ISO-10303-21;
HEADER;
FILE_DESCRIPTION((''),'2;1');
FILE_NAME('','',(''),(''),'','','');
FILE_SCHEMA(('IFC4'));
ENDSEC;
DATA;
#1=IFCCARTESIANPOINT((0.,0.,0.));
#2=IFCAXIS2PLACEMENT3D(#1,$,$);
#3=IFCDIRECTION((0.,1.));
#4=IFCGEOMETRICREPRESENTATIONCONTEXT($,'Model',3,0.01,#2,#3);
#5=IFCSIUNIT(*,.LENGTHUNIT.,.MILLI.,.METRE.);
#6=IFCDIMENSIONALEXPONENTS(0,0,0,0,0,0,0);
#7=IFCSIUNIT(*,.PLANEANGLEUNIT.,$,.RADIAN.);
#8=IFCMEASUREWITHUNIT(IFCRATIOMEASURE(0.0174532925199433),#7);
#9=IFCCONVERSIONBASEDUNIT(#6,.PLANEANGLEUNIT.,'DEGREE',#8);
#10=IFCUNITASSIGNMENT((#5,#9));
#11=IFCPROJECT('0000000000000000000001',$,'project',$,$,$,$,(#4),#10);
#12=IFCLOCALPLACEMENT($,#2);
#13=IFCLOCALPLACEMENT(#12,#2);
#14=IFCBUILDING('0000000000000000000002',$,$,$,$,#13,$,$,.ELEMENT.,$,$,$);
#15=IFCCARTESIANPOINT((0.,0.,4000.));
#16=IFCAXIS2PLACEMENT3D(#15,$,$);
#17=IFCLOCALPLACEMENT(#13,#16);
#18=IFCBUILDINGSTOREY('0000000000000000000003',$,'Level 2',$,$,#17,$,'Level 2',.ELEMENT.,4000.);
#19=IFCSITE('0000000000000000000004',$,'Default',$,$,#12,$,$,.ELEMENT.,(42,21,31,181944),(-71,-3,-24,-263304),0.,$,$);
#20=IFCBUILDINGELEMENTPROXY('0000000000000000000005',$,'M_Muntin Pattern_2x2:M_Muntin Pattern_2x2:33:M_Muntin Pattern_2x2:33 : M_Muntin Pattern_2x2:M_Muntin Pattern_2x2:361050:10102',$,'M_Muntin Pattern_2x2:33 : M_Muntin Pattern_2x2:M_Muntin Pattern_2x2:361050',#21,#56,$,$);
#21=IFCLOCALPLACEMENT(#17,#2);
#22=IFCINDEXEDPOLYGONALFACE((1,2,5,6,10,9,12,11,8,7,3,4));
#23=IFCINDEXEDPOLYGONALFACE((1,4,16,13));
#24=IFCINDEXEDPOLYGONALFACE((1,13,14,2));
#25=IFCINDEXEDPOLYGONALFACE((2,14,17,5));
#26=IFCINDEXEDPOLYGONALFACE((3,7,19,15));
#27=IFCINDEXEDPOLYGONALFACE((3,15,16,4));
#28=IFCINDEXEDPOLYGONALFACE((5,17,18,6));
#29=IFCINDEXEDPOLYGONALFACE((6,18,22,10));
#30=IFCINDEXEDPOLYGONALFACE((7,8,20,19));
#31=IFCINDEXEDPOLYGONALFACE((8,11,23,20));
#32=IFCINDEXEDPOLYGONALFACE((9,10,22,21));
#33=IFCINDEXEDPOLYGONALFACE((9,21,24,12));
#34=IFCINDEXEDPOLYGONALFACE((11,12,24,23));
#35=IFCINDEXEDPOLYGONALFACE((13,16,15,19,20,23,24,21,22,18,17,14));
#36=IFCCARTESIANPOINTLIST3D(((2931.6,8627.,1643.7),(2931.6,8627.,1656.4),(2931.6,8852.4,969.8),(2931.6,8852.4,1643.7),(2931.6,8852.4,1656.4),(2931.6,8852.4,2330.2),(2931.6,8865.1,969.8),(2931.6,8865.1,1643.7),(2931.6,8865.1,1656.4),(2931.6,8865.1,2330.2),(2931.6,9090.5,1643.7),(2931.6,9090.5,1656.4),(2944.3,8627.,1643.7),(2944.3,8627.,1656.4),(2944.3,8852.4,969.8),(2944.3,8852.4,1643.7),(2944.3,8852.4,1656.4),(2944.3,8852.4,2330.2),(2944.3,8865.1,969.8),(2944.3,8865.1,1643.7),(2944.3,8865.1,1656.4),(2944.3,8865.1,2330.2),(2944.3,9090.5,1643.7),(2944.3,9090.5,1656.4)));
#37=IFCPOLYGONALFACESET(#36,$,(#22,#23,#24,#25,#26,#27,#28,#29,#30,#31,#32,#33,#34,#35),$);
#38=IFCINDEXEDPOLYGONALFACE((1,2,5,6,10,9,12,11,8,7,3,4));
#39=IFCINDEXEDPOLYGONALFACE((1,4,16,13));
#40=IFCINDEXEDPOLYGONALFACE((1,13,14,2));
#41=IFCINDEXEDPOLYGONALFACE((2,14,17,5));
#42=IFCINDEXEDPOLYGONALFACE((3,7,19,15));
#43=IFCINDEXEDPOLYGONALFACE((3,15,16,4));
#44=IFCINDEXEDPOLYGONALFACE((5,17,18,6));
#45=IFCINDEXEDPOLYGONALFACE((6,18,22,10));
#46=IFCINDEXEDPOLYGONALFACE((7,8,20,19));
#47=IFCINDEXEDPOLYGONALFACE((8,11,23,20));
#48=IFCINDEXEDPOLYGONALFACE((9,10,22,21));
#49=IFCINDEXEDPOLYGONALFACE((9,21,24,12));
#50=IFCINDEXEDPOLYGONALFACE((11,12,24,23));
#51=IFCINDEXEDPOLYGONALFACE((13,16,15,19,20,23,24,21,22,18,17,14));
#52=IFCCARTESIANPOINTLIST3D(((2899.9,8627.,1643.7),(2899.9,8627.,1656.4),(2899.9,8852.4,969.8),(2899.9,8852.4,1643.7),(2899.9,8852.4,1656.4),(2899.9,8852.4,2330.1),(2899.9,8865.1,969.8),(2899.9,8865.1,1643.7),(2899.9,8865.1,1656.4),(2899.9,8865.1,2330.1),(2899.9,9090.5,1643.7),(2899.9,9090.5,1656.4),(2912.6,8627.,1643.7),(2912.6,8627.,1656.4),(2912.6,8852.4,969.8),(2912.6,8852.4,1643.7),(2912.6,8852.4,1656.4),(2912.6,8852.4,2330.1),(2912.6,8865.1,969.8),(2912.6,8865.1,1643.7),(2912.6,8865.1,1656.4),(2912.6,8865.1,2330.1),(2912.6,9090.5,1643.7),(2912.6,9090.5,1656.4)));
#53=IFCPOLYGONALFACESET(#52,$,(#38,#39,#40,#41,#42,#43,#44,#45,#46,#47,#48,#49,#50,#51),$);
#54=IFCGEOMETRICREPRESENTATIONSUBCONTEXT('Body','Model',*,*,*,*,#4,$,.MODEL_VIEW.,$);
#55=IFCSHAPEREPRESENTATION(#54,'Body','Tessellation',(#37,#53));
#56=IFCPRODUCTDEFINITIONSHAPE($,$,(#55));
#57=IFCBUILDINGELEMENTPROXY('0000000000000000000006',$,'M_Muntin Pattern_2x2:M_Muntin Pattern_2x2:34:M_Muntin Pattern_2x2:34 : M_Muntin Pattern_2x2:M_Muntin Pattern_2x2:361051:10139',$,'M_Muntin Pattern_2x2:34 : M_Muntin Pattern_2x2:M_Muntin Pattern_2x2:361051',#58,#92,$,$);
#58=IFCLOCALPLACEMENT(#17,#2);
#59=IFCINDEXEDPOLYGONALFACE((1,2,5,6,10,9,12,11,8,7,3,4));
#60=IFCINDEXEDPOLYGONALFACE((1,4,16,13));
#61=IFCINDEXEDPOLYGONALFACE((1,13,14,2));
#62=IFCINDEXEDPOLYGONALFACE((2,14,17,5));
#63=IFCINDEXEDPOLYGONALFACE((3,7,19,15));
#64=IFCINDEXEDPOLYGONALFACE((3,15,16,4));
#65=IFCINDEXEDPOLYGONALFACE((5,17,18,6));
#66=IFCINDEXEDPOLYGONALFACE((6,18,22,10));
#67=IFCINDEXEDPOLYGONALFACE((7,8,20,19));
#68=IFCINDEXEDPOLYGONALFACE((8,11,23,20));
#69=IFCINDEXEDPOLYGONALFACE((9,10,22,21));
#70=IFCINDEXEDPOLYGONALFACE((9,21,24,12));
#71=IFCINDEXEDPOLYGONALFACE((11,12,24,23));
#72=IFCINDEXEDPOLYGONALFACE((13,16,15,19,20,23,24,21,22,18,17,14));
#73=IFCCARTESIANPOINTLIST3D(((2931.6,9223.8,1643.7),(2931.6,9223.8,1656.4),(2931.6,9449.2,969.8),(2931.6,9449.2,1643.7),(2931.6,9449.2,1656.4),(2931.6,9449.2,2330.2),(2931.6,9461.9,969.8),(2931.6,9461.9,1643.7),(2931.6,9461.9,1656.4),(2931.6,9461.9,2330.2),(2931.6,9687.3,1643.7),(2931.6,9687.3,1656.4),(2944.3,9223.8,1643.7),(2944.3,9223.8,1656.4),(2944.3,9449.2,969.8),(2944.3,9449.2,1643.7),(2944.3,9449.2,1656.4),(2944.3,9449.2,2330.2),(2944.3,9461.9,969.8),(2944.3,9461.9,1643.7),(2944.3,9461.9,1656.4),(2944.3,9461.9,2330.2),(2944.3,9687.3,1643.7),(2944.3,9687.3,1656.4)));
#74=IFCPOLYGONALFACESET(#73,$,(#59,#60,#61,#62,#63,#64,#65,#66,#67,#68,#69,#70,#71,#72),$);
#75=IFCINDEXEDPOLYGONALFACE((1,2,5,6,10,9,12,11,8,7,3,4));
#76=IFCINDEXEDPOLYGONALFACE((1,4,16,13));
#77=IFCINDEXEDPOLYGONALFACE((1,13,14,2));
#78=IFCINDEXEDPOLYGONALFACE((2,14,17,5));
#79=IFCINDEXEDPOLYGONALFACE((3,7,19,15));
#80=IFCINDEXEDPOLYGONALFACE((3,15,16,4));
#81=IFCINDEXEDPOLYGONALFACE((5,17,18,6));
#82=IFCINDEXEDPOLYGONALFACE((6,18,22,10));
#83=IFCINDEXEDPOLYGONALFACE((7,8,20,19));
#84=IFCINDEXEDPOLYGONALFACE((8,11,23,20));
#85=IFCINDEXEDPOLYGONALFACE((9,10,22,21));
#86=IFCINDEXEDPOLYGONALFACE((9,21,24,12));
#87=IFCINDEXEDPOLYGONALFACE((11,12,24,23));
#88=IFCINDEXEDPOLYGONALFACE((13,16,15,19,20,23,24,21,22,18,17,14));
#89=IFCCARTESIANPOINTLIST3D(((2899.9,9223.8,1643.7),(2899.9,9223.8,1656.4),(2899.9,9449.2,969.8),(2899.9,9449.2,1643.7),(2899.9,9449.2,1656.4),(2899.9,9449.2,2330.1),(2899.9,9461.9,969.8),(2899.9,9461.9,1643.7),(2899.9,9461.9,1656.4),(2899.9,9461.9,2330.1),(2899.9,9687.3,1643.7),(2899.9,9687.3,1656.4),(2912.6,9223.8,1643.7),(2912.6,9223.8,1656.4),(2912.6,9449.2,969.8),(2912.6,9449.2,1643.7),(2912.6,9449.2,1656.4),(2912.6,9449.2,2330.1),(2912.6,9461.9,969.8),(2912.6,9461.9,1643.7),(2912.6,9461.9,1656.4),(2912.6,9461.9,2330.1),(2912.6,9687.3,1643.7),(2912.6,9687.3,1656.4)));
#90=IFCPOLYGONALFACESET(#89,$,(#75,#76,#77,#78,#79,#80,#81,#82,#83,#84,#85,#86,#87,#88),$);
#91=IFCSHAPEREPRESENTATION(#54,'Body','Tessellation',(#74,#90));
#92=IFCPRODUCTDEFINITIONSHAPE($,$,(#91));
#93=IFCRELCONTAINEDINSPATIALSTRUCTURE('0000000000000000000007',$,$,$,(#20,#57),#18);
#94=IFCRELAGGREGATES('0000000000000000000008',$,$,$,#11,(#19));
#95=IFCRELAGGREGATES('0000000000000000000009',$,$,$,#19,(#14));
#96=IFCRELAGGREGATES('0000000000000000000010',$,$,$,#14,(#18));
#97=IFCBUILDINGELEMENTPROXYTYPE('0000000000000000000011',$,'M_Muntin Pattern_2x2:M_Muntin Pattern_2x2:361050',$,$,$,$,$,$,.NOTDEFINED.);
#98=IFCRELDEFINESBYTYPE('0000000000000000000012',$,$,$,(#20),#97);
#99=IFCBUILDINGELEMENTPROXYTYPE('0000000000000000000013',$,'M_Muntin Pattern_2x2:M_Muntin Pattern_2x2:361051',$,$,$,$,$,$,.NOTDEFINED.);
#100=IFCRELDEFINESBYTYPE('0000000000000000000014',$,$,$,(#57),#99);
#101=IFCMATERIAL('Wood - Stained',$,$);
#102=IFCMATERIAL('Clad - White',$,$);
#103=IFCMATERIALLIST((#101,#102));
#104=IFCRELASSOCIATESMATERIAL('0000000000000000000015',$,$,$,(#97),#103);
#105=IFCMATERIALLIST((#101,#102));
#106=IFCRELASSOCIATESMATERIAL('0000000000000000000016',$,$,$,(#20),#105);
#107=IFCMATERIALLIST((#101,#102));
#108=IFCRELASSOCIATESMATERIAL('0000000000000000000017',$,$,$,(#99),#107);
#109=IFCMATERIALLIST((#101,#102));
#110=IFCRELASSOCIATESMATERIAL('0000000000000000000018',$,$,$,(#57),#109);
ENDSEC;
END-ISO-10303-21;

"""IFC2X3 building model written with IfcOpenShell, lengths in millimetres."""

from ifc_helpers import new_model, entity, si_unit, converted_unit, direction, frame, origin, place, context, subcontext, project, spatial, polyline, outline, extrude, source, transform, mapped, material, material_list, type_object, type_shapes, element, save


model = new_model("IFC2X3")

# Units and contexts
model_context = context("Model", 3, precision=0.01, world=origin(), true_north=direction((0.0, 1.0)))
body_context = subcontext(model_context, "Body", "Model", "MODEL_VIEW")
ifc_project = project(units=[si_unit("LENGTHUNIT", "METRE", prefix="MILLI"), converted_unit("PLANEANGLEUNIT", "DEGREE", entity("IfcRatioMeasure", 0.0174532925199433), si_unit("PLANEANGLEUNIT", "RADIAN"), dimensions=[0, 0, 0, 0, 0, 0, 0])], contexts=[model_context])

# Site, building, storey
site_placement = place(None, origin())
site = spatial("IfcSite", under=ifc_project, at=site_placement, Name="Default", CompositionType="ELEMENT", RefLatitude=(42, 21, 31, 181944), RefLongitude=(-71, -3, -24, -263304), RefElevation=0.0)
building_placement = place(site_placement, origin())
building = spatial("IfcBuilding", under=site, at=building_placement, CompositionType="ELEMENT")
storey_placement = place(building_placement, frame((0.0, 0.0, 4000.0)))
storey = spatial("IfcBuildingStorey", under=building, at=storey_placement, Name="Level 2", LongName="Level 2", CompositionType="ELEMENT", Elevation=4000.0)

# Building element proxies
ifc_material_1 = material(Name="Wood - Stained")
ifc_material_2 = material(Name="Clad - White")
ifc_material_list_1 = material_list([ifc_material_1, ifc_material_2])
ifc_material_list_2 = material_list([ifc_material_1, ifc_material_2])
building_element_proxy_type_1 = type_object("IfcBuildingElementProxyType", Name="M_Muntin Pattern_2x2:M_Muntin Pattern_2x2:361050", PredefinedType="NOTDEFINED", material=ifc_material_list_2)
shared_shape_1 = source(origin(), body_context, "Body", "SweptSolid", [
    extrude(outline(polyline([(-680.2, 6.4), (-680.2, -6.3), (-6.4, -6.3), (-6.4, -231.7), (6.3, -231.7), (6.3, -6.3), (680.2, -6.3), (680.2, 6.4), (6.3, 6.4), (6.3, 231.7), (-6.4, 231.7), (-6.4, 6.4), (-680.2, 6.4)])), frame((2931.6, 8858.7, 5650.0), z_axis=(-1.0, 0.0, 0.0), x_axis=(0.0, 0.0, -1.0)), (0.0, 0.0, -1.0), 12.7),
    extrude(outline(polyline([(-680.1, 6.4), (-680.1, -6.3), (-6.4, -6.3), (-6.4, -231.7), (6.3, -231.7), (6.3, -6.3), (680.2, -6.3), (680.2, 6.4), (6.3, 6.4), (6.3, 231.7), (-6.4, 231.7), (-6.4, 6.4), (-680.1, 6.4)])), frame((2899.9, 8858.7, 5650.0), z_axis=(-1.0, 0.0, 0.0), x_axis=(0.0, 0.0, -1.0)), (0.0, 0.0, -1.0), 12.7),
])
type_shapes(building_element_proxy_type_1, [shared_shape_1])
proxy_1_placement = place(storey_placement, frame((0.0, 0.0, -4000.0)))
element("IfcBuildingElementProxy", 1, at=proxy_1_placement, inside=storey, type_object=building_element_proxy_type_1, material=ifc_material_list_1, Name="M_Muntin Pattern_2x2:M_Muntin Pattern_2x2:33:M_Muntin Pattern_2x2:33 : M_Muntin Pattern_2x2:M_Muntin Pattern_2x2:361050:10102", ObjectType="M_Muntin Pattern_2x2:33 : M_Muntin Pattern_2x2:M_Muntin Pattern_2x2:361050", context=body_context, shape_type="MappedRepresentation", body=[
    mapped(shared_shape_1, transform((0.0, 0.0, 0.0), scale=1.0)),
])
ifc_material_list_3 = material_list([ifc_material_1, ifc_material_2])
ifc_material_list_4 = material_list([ifc_material_1, ifc_material_2])
building_element_proxy_type_2 = type_object("IfcBuildingElementProxyType", Name="M_Muntin Pattern_2x2:M_Muntin Pattern_2x2:361051", PredefinedType="NOTDEFINED", material=ifc_material_list_4)
shared_shape_2 = source(origin(), body_context, "Body", "SweptSolid", [
    extrude(outline(polyline([(-6.4, -680.1), (6.3, -680.1), (6.3, -6.4), (231.7, -6.4), (231.7, 6.3), (6.3, 6.3), (6.3, 680.2), (-6.4, 680.2), (-6.4, 6.3), (-231.7, 6.3), (-231.7, -6.4), (-6.4, -6.4), (-6.4, -680.1)])), frame((2931.6, 9455.6, 5650.0), z_axis=(1.0, 0.0, 0.0), x_axis=(0.0, -1.0, 0.0)), (0.0, 0.0, 1.0), 12.7),
    extrude(outline(polyline([(-6.4, -680.1), (6.3, -680.1), (6.3, -6.4), (231.7, -6.4), (231.7, 6.3), (6.3, 6.3), (6.3, 680.2), (-6.4, 680.2), (-6.4, 6.3), (-231.7, 6.3), (-231.7, -6.4), (-6.4, -6.4), (-6.4, -680.1)])), frame((2899.9, 9455.6, 5650.0), z_axis=(1.0, 0.0, 0.0), x_axis=(0.0, -1.0, 0.0)), (0.0, 0.0, 1.0), 12.7),
])
type_shapes(building_element_proxy_type_2, [shared_shape_2])
proxy_2_placement = place(storey_placement, frame((0.0, 0.0, -4000.0)))
element("IfcBuildingElementProxy", 2, at=proxy_2_placement, inside=storey, type_object=building_element_proxy_type_2, material=ifc_material_list_3, Name="M_Muntin Pattern_2x2:M_Muntin Pattern_2x2:34:M_Muntin Pattern_2x2:34 : M_Muntin Pattern_2x2:M_Muntin Pattern_2x2:361051:10139", ObjectType="M_Muntin Pattern_2x2:34 : M_Muntin Pattern_2x2:M_Muntin Pattern_2x2:361051", context=body_context, shape_type="MappedRepresentation", body=[
    mapped(shared_shape_2, transform((0.0, 0.0, 0.0), scale=1.0)),
])

save(model, "model.ifc")
